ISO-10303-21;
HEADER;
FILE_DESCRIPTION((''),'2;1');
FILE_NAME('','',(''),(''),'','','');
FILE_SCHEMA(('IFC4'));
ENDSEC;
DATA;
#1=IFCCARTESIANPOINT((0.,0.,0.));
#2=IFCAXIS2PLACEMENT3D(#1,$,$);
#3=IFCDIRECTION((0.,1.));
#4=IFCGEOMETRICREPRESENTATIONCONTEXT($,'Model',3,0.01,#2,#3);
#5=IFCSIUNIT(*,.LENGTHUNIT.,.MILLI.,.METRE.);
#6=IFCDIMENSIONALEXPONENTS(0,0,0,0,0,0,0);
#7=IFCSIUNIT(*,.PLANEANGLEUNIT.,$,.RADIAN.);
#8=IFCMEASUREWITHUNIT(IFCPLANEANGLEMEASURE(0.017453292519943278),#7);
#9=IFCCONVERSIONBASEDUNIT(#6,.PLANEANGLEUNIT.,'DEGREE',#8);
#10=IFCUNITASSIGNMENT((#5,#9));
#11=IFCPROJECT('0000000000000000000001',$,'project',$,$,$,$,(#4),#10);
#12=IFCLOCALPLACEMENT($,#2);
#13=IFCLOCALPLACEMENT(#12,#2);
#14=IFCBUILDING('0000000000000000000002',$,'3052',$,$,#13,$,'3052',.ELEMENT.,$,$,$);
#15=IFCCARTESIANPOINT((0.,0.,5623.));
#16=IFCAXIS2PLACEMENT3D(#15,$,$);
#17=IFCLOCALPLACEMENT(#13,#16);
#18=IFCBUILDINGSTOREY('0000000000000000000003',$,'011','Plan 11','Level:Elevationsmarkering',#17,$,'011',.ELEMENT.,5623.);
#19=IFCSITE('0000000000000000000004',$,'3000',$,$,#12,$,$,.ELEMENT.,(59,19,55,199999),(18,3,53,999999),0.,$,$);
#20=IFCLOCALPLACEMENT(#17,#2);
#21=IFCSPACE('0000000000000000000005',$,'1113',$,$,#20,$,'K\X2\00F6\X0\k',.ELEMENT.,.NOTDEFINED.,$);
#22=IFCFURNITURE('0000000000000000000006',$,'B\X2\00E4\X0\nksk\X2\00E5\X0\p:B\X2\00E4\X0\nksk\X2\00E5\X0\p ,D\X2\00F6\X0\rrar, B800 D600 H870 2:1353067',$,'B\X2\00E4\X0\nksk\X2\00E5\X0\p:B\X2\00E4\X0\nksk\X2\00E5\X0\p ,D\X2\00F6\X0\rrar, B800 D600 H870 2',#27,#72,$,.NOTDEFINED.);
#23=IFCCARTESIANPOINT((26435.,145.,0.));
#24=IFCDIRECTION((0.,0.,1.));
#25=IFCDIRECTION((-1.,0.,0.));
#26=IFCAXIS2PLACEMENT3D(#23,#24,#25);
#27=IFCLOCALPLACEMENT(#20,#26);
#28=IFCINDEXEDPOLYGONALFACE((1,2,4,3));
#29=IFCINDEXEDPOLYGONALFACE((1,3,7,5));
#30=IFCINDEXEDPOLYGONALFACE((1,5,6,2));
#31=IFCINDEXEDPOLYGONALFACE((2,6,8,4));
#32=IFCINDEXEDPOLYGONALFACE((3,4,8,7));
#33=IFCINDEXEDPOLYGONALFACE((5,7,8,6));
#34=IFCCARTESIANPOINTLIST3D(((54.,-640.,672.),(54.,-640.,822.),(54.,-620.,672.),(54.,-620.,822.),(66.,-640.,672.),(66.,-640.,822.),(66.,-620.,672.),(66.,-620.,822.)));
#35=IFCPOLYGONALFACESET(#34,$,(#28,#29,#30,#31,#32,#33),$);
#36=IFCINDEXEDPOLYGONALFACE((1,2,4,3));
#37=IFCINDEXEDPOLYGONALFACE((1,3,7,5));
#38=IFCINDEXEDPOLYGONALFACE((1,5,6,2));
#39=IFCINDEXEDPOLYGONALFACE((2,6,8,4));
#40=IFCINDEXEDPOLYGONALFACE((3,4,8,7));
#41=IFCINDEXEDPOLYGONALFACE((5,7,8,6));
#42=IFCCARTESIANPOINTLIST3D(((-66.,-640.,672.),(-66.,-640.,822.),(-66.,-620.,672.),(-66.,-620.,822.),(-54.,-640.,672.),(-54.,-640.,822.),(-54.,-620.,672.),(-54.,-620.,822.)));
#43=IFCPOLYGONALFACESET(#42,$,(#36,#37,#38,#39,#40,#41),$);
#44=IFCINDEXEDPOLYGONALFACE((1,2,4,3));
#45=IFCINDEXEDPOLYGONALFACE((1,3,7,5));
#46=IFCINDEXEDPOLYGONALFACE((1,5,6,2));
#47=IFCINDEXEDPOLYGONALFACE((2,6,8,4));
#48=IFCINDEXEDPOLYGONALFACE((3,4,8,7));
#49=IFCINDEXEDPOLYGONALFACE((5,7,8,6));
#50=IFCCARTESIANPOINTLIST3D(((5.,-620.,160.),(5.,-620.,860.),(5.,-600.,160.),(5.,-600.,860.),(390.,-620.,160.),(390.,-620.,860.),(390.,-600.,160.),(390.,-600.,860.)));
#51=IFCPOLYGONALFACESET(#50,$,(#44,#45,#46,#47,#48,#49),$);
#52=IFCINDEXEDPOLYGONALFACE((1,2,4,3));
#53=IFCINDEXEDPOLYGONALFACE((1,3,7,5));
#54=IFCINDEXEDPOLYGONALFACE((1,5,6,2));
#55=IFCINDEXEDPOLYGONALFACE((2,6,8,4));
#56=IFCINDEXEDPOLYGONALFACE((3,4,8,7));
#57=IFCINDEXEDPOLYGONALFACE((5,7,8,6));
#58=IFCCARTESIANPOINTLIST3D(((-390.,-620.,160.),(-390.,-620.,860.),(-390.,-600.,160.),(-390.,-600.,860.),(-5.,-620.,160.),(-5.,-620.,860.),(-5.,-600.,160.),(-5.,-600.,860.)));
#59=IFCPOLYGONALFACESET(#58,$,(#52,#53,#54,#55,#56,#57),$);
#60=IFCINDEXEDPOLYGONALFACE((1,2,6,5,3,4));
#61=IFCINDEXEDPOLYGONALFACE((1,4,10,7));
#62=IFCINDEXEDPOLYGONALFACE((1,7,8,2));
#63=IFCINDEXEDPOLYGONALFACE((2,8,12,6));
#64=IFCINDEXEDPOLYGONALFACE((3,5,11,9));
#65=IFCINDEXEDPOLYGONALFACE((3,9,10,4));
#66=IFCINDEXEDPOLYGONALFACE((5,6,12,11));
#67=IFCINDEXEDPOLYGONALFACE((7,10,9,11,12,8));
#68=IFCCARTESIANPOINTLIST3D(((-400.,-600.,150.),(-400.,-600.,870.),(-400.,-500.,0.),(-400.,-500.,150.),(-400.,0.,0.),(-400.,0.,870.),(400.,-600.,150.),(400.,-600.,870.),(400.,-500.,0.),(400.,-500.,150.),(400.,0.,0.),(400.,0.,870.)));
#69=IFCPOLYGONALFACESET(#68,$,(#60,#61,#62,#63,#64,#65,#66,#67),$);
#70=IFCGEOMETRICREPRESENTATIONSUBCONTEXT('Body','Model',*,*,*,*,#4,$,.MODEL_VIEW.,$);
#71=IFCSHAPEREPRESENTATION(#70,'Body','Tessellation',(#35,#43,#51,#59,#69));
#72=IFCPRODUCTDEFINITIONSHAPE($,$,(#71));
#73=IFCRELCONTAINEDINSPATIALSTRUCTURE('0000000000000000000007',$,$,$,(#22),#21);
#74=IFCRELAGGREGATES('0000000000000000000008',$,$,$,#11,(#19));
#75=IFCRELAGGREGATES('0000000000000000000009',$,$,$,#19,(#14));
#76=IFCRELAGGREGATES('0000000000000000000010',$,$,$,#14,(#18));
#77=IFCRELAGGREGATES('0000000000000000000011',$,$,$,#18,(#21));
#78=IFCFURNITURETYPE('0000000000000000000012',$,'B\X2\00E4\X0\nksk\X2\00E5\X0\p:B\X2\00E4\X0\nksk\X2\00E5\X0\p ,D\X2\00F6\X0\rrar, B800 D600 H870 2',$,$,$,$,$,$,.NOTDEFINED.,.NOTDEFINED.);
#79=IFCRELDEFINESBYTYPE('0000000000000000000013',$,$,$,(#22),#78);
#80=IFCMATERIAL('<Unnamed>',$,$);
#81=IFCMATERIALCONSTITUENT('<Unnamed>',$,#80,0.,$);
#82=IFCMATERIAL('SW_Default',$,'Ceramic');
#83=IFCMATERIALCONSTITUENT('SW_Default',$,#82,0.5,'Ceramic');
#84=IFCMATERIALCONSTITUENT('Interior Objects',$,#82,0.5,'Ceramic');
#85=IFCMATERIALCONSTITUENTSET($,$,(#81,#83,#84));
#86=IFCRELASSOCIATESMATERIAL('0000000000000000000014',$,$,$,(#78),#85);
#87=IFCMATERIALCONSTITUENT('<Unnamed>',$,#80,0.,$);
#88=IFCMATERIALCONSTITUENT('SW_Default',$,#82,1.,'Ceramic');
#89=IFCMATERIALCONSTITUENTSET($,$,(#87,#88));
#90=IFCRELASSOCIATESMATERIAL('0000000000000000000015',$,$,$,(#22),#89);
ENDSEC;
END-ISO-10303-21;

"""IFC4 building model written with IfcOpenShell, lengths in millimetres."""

from ifc_helpers import new_model, entity, si_unit, converted_unit, direction, frame, origin, place, context, subcontext, project, spatial, indexed_curve, outline, extrude, source, transform, mapped, material, constituent, constituent_set, type_object, type_shapes, element, save


model = new_model("IFC4")

# Units and contexts
model_context = context("Model", 3, precision=0.01, world=origin(), true_north=direction((0.0, 1.0)))
body_context = subcontext(model_context, "Body", "Model", "MODEL_VIEW")
ifc_project = project(units=[si_unit("LENGTHUNIT", "METRE", prefix="MILLI"), converted_unit("PLANEANGLEUNIT", "DEGREE", entity("IfcPlaneAngleMeasure", 0.017453292519943278), si_unit("PLANEANGLEUNIT", "RADIAN"), dimensions=[0, 0, 0, 0, 0, 0, 0])], contexts=[model_context])

# Site, building, storey
site_placement = place(None, origin())
site = spatial("IfcSite", under=ifc_project, at=site_placement, Name="3000", CompositionType="ELEMENT", RefLatitude=(59, 19, 55, 199999), RefLongitude=(18, 3, 53, 999999), RefElevation=0.0)
building_placement = place(site_placement, origin())
building = spatial("IfcBuilding", under=site, at=building_placement, Name="3052", LongName="3052", CompositionType="ELEMENT")
storey_placement = place(building_placement, frame((0.0, 0.0, 5623.0)))
storey = spatial("IfcBuildingStorey", under=building, at=storey_placement, Name="011", Description="Plan 11", ObjectType="Level:Elevationsmarkering", LongName="011", CompositionType="ELEMENT", Elevation=5623.0)

# Shared definitions
ifc_material_1 = material(Name="<Unnamed>")

# Shared definitions
space_placement = place(storey_placement, origin())
space = spatial("IfcSpace", under=storey, at=space_placement, Name="1113", LongName="Kök", CompositionType="ELEMENT", PredefinedType="NOTDEFINED")

# Furniture
ifc_constituent_1 = constituent(ifc_material_1, Name="<Unnamed>", fraction=0.0)
ifc_material_2 = material(Name="SW_Default", Category="Ceramic")
ifc_constituent_2 = constituent(ifc_material_2, Name="SW_Default", Category="Ceramic", fraction=1.0)
ifc_constituent_set_1 = constituent_set(constituents=[ifc_constituent_1, ifc_constituent_2])
ifc_constituent_3 = constituent(ifc_material_1, Name="<Unnamed>", fraction=0.0)
ifc_constituent_4 = constituent(ifc_material_2, Name="SW_Default", Category="Ceramic", fraction=0.5)
ifc_constituent_5 = constituent(ifc_material_2, Name="Interior Objects", Category="Ceramic", fraction=0.5)
ifc_constituent_set_2 = constituent_set(constituents=[ifc_constituent_3, ifc_constituent_4, ifc_constituent_5])
furniture_type_1 = type_object("IfcFurnitureType", Name="Bänkskåp:Bänkskåp ,Dörrar, B800 D600 H870 2", AssemblyPlace="NOTDEFINED", PredefinedType="NOTDEFINED", material=ifc_constituent_set_2)
shared_shape_1 = source(origin(), body_context, "Body", "SweptSolid", [
    extrude(outline(indexed_curve([(-6.0, -10.0), (6.0, -10.0), (6.0, 10.0), (-6.0, 10.0), (-6.0, -10.0)], self_intersect=False)), frame((60.0, -630.0, 672.0), z_axis=(0.0, 0.0, 1.0), x_axis=(-1.0, 0.0, 0.0)), (0.0, 0.0, 1.0), 150.0),
    extrude(outline(indexed_curve([(-6.0, -10.0), (6.0, -10.0), (6.0, 10.0), (-6.0, 10.0), (-6.0, -10.0)], self_intersect=False)), frame((-60.0, -630.0, 672.0), z_axis=(0.0, 0.0, 1.0), x_axis=(-1.0, 0.0, 0.0)), (0.0, 0.0, 1.0), 150.0),
    extrude(outline(indexed_curve([(-192.5, -10.0), (192.5, -10.0), (192.5, 10.0), (-192.5, 10.0), (-192.5, -10.0)], self_intersect=False)), frame((197.5, -610.0, 160.0)), (0.0, 0.0, 1.0), 700.0),
    extrude(outline(indexed_curve([(-192.5, -10.0), (192.5, -10.0), (192.5, 10.0), (-192.5, 10.0), (-192.5, -10.0)], self_intersect=False)), frame((-197.5, -610.0, 160.0), z_axis=(0.0, 0.0, 1.0), x_axis=(-1.0, 0.0, 0.0)), (0.0, 0.0, 1.0), 700.0),
    extrude(outline(indexed_curve([(-366.7, -530.0), (233.3, -530.0), (233.3, 190.0), (133.3, 190.0), (133.3, 340.0), (-366.7, 340.0), (-366.7, -530.0)], self_intersect=False)), frame((-400.0, -366.7, 340.0), z_axis=(1.0, 0.0, 0.0), x_axis=(0.0, -1.0, 0.0)), (0.0, 0.0, 1.0), 800.0),
])
type_shapes(furniture_type_1, [shared_shape_1])
furniture_1_placement = place(space_placement, frame((26435.0, 145.0, 0.0), z_axis=(0.0, 0.0, 1.0), x_axis=(-1.0, 0.0, 0.0)))
element("IfcFurniture", 1, at=furniture_1_placement, inside=space, type_object=furniture_type_1, material=ifc_constituent_set_1, Name="Bänkskåp:Bänkskåp ,Dörrar, B800 D600 H870 2:1353067", ObjectType="Bänkskåp:Bänkskåp ,Dörrar, B800 D600 H870 2", PredefinedType="NOTDEFINED", context=body_context, shape_type="MappedRepresentation", body=[
    mapped(shared_shape_1, transform((0.0, 0.0, 0.0), scale=1.0)),
])

save(model, "model.ifc")
